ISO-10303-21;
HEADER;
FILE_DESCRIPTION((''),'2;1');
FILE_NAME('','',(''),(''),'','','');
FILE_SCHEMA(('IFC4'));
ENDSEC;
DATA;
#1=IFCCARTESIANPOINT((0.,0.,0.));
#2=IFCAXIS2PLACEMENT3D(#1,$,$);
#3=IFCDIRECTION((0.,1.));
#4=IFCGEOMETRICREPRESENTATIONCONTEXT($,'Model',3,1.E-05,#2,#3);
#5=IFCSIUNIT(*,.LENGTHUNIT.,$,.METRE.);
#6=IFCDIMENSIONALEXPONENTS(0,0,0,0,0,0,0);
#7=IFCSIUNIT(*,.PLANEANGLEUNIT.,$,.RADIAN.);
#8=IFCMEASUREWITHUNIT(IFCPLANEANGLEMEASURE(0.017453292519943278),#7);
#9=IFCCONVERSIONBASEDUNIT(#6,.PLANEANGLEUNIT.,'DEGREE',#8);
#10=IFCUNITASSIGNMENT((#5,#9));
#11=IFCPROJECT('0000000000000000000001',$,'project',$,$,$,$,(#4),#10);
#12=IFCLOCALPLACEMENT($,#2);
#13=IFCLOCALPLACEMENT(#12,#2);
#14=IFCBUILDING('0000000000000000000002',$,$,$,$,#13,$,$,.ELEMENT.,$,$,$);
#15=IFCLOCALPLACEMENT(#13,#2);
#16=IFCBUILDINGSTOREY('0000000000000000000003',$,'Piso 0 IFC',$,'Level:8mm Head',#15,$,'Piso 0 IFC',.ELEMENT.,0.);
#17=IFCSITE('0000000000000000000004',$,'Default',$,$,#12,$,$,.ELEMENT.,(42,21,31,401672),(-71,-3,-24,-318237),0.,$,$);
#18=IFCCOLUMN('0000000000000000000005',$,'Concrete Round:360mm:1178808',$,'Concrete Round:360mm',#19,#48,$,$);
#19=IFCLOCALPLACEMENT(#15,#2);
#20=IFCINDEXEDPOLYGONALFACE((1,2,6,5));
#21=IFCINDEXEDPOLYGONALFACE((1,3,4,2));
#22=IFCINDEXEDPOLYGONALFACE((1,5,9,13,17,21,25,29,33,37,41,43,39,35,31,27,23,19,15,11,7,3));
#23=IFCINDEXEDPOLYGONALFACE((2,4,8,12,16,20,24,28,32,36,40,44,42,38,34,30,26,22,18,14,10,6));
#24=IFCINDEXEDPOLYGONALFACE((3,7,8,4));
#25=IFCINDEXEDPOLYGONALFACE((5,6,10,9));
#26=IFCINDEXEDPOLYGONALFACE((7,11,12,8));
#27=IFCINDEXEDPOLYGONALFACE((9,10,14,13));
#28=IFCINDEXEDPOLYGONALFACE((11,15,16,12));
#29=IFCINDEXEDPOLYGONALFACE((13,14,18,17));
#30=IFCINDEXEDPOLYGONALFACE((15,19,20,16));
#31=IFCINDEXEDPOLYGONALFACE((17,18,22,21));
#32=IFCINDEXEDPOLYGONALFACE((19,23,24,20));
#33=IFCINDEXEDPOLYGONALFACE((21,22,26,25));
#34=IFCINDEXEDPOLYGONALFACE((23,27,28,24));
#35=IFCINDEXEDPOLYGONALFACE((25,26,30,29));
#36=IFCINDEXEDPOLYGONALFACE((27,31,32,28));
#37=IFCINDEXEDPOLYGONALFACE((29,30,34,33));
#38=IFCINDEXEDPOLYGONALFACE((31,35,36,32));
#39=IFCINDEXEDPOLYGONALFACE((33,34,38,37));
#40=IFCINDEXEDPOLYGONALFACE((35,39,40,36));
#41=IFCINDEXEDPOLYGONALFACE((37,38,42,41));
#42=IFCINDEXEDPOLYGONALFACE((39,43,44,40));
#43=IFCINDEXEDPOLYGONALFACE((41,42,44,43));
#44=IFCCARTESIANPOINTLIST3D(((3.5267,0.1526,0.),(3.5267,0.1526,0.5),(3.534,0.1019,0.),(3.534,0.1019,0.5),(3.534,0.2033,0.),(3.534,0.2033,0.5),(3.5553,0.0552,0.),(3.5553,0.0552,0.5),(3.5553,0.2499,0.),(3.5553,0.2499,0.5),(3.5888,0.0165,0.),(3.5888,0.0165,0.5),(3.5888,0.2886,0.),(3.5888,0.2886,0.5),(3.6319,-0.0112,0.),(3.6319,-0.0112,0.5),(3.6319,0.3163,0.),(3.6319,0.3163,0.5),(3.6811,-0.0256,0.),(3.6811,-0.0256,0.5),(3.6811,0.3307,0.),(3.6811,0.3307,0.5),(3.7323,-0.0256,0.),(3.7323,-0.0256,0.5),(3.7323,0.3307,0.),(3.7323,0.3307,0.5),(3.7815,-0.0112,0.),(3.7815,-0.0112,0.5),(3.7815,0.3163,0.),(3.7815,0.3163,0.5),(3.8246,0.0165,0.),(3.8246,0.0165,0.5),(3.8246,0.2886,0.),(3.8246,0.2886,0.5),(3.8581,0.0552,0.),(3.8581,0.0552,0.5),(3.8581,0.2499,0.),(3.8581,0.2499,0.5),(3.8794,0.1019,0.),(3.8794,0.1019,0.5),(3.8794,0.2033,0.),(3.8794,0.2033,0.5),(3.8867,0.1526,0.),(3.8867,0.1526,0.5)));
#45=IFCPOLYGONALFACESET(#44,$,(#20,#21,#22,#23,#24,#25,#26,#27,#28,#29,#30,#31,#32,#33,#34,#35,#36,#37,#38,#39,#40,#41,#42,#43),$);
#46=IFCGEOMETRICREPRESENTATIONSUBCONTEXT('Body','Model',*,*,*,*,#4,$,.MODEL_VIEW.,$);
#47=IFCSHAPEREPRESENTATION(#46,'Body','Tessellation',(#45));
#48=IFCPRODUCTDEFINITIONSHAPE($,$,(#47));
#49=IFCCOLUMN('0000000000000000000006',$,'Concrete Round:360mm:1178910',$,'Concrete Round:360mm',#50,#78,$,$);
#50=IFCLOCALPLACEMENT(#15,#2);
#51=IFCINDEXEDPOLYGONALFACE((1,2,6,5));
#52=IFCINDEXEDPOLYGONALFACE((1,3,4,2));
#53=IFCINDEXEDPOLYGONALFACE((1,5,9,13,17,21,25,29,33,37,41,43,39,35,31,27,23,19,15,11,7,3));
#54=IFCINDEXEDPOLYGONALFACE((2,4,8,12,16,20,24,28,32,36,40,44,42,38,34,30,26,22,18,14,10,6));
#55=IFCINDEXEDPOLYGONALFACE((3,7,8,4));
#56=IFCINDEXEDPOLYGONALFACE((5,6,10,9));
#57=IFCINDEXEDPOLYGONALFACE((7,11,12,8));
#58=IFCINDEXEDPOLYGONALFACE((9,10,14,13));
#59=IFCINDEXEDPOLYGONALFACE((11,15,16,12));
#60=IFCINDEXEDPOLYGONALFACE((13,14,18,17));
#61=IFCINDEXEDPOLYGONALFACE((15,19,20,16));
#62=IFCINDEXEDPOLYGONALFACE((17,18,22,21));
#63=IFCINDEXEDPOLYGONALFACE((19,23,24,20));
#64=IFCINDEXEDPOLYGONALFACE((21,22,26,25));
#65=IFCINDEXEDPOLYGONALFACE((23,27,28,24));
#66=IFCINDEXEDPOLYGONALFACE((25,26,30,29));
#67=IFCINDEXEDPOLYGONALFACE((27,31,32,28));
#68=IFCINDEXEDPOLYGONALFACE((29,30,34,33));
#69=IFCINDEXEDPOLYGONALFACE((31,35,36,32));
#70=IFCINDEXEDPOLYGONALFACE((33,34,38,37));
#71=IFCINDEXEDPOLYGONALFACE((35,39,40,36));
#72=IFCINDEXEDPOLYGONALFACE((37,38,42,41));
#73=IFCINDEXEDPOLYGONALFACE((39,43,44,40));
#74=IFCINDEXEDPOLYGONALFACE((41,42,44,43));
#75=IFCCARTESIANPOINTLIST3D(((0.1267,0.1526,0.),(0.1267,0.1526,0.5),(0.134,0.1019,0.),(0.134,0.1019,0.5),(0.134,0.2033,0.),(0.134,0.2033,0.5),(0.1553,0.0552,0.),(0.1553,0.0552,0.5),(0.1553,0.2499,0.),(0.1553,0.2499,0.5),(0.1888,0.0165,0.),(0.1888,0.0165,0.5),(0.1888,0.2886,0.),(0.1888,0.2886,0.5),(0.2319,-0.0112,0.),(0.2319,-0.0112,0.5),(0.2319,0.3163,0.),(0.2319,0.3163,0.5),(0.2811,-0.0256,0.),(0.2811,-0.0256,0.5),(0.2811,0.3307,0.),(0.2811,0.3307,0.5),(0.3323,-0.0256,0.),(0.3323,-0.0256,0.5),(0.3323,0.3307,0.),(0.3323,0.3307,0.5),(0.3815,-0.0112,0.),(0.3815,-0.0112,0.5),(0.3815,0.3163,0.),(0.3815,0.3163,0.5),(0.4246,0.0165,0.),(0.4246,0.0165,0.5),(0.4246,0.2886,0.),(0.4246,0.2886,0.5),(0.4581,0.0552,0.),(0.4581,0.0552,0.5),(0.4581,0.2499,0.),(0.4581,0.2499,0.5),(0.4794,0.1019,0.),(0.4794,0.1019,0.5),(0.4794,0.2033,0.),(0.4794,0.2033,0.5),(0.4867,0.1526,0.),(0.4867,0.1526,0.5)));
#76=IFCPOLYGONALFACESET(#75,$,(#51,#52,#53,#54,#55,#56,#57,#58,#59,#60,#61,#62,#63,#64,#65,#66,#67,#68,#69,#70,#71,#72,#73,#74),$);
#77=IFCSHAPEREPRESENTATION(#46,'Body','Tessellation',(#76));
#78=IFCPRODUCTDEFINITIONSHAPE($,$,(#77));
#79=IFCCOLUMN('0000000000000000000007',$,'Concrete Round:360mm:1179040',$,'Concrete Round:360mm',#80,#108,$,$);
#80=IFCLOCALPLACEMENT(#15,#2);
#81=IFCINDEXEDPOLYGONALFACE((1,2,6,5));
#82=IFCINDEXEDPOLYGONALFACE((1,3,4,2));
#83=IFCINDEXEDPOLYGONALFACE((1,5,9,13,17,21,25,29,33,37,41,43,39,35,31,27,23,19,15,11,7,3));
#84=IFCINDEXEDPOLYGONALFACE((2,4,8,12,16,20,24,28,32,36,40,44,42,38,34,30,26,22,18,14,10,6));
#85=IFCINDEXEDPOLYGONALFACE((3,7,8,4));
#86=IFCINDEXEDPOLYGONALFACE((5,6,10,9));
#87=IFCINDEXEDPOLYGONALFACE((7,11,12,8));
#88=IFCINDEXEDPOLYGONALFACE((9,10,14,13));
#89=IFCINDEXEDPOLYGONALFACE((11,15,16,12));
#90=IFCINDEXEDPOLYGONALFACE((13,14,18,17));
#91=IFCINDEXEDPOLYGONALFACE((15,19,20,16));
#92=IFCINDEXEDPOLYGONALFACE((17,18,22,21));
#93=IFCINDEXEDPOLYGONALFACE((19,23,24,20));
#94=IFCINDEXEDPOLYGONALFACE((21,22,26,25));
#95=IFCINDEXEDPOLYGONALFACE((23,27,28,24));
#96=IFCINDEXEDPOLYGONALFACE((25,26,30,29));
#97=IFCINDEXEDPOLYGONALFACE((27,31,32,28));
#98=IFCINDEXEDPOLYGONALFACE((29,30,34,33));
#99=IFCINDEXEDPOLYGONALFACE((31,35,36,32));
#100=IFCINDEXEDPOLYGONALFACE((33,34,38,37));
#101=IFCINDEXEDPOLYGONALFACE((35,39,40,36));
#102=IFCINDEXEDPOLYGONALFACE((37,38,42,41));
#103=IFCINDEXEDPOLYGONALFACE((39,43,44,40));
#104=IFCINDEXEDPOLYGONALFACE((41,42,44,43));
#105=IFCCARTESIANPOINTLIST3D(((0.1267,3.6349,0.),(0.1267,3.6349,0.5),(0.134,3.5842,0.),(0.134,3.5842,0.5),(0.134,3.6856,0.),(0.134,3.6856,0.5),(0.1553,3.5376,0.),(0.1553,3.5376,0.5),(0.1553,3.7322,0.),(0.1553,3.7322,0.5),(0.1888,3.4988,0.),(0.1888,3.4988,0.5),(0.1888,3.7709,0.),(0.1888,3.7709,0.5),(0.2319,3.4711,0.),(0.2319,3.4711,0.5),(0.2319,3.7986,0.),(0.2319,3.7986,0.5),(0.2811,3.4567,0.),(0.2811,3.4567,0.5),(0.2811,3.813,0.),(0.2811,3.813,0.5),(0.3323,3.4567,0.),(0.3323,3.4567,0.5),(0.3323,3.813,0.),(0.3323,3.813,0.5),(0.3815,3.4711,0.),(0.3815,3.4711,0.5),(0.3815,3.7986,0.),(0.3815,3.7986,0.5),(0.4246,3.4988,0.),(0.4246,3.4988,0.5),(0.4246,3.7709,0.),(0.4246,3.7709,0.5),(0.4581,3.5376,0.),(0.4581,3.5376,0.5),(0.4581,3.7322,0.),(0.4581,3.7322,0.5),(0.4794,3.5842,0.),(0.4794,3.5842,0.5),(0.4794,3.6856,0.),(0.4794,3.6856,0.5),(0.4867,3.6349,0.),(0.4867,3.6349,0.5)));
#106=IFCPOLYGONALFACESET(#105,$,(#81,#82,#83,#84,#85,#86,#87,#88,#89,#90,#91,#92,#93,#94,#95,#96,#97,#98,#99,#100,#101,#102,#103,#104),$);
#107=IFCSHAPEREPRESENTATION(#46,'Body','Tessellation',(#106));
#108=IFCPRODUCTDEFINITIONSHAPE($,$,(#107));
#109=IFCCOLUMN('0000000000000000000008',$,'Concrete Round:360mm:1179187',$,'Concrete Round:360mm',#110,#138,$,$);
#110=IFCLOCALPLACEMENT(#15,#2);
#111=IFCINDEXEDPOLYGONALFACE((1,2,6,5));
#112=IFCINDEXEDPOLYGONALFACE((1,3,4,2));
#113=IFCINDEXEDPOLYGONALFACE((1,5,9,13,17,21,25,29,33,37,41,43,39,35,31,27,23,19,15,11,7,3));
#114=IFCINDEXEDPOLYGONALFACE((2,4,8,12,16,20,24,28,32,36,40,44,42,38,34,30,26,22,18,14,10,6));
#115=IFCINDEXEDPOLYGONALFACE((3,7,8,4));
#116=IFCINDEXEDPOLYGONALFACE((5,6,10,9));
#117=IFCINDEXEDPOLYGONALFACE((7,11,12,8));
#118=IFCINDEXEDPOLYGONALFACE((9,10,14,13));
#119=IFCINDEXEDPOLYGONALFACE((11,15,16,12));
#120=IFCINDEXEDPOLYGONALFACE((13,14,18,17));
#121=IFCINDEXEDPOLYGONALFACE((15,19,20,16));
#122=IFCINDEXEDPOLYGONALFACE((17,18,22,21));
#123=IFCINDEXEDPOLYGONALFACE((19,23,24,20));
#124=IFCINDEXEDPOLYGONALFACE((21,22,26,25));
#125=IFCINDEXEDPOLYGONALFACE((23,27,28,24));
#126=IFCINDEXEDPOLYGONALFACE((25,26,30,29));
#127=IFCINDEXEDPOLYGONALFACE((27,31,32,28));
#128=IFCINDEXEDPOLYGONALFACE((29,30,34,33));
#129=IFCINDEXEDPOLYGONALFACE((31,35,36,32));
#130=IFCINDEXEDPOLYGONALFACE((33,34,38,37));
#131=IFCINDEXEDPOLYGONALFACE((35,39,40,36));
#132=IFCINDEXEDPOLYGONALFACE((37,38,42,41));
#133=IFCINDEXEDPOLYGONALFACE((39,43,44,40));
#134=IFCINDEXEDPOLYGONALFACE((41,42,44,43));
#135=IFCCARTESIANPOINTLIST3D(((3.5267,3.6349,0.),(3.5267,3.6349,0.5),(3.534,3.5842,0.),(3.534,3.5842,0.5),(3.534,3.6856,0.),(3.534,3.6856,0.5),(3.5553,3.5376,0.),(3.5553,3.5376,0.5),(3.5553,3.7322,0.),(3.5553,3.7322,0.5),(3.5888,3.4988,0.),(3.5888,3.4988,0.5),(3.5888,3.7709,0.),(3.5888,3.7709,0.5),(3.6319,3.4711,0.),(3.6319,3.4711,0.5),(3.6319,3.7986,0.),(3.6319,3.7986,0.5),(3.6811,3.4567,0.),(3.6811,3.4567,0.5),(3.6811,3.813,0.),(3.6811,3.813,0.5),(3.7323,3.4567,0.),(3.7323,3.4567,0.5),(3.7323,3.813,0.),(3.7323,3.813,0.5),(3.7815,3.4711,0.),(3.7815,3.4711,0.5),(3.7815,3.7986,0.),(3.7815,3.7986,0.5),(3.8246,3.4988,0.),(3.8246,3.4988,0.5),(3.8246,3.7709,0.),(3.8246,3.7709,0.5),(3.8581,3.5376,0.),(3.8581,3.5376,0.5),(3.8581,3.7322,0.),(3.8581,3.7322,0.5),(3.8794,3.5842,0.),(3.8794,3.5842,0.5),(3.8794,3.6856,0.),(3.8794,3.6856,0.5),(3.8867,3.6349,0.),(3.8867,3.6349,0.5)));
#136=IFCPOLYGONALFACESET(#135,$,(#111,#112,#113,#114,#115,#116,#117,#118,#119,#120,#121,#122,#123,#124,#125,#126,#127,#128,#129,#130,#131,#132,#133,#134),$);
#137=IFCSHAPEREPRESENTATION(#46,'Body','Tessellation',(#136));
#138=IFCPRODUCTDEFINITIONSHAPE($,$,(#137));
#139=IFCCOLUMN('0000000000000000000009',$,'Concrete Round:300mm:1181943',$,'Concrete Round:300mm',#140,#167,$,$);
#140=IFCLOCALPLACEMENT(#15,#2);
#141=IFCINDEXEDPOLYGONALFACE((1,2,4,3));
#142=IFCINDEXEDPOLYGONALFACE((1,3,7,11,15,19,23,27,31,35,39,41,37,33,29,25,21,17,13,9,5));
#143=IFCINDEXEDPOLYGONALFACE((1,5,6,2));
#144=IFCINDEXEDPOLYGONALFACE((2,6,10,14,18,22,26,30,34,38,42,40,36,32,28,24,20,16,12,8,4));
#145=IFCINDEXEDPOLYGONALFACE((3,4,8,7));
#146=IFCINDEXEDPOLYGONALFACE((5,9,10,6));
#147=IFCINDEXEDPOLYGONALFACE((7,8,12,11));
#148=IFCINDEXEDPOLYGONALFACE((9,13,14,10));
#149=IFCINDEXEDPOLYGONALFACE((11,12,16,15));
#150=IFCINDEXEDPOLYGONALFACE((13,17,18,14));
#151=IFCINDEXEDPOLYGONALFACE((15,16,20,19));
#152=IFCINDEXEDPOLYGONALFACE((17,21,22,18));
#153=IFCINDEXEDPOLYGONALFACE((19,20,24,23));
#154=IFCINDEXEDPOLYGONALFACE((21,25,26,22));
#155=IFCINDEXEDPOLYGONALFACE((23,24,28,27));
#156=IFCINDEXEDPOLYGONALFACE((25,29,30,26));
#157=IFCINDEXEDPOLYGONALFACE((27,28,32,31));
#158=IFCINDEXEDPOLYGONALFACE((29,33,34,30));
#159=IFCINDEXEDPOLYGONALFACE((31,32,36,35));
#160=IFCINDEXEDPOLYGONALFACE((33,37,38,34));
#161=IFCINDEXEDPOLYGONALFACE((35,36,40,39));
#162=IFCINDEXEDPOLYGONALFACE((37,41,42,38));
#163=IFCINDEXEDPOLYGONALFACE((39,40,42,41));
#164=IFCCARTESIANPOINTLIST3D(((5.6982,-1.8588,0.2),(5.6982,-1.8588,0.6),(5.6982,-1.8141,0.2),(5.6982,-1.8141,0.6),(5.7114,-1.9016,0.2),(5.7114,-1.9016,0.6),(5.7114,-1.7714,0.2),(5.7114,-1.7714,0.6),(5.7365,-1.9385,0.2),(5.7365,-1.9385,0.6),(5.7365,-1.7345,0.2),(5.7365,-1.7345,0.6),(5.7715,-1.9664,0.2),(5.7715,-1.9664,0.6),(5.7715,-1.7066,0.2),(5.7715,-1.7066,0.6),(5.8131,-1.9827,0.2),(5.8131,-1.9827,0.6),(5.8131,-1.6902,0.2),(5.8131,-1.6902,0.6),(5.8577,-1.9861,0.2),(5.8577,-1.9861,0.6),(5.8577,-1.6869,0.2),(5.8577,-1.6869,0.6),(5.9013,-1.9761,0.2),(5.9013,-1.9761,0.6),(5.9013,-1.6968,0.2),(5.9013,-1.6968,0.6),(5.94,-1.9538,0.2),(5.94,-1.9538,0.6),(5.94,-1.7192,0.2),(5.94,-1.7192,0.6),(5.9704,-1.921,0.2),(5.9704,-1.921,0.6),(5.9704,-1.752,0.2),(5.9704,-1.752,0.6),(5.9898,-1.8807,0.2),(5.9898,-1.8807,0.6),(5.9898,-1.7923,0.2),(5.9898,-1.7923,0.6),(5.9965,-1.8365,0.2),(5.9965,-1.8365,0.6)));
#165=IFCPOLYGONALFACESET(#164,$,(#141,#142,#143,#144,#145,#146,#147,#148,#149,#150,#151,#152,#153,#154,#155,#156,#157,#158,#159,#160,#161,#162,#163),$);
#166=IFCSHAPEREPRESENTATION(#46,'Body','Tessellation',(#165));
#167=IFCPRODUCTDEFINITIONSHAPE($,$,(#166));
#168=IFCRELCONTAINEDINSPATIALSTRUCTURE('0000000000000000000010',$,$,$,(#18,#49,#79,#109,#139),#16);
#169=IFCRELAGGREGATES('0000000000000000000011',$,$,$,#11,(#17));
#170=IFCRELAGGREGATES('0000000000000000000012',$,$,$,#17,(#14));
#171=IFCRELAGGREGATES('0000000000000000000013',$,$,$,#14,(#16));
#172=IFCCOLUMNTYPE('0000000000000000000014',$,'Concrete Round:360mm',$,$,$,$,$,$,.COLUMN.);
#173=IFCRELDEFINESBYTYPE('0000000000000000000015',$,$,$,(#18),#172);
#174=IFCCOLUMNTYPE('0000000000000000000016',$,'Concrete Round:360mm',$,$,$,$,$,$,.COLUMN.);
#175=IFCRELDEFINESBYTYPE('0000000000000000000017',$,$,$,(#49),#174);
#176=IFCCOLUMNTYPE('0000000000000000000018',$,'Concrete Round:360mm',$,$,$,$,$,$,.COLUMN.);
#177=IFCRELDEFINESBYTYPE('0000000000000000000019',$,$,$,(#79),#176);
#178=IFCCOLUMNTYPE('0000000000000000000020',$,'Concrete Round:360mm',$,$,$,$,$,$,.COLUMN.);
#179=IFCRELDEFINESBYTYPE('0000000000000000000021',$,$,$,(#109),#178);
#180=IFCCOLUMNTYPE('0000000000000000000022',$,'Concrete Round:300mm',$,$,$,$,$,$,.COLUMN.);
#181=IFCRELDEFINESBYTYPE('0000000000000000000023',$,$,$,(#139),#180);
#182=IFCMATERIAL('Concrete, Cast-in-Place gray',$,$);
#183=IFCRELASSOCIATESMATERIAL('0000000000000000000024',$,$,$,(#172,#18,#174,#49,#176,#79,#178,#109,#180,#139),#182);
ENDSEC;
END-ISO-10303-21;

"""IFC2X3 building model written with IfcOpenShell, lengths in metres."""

from ifc_helpers import new_model, entity, si_unit, converted_unit, direction, frame, frame_2d, origin, origin_2d_with_axis, place, context, subcontext, project, spatial, circle, extrude, source, transform, mapped, material, type_object, type_shapes, element, save


model = new_model("IFC2X3")

# Units and contexts
model_context = context("Model", 3, precision=1e-05, world=origin(), true_north=direction((0.0, 1.0)))
body_context = subcontext(model_context, "Body", "Model", "MODEL_VIEW")
ifc_project = project(units=[si_unit("LENGTHUNIT", "METRE"), converted_unit("PLANEANGLEUNIT", "DEGREE", entity("IfcPlaneAngleMeasure", 0.017453292519943278), si_unit("PLANEANGLEUNIT", "RADIAN"), dimensions=[0, 0, 0, 0, 0, 0, 0])], contexts=[model_context])

# Site, building, storey
site_placement = place(None, origin())
site = spatial("IfcSite", under=ifc_project, at=site_placement, Name="Default", CompositionType="ELEMENT", RefLatitude=(42, 21, 31, 401672), RefLongitude=(-71, -3, -24, -318237), RefElevation=0.0)
building_placement = place(site_placement, origin())
building = spatial("IfcBuilding", under=site, at=building_placement, CompositionType="ELEMENT")
storey_placement = place(building_placement, origin())
storey = spatial("IfcBuildingStorey", under=building, at=storey_placement, Name="Piso 0 IFC", ObjectType="Level:8mm Head", LongName="Piso 0 IFC", CompositionType="ELEMENT", Elevation=0.0)

# Columns
ifc_material_1 = material(Name="Concrete, Cast-in-Place gray")
column_type_1 = type_object("IfcColumnType", Name="Concrete Round:360mm", PredefinedType="COLUMN", material=ifc_material_1)
shared_shape_1 = source(origin(), body_context, "Body", "SweptSolid", [
    extrude(circle(Radius=0.18, at=frame_2d((0.0, 0.0), x_axis=(1.0, 0.0))), frame((3.7067, 0.1526, 0.0)), (0.0, 0.0, 1.0), 0.5),
])
type_shapes(column_type_1, [shared_shape_1])
column_1_placement = place(storey_placement, origin())
element("IfcColumn", 1, at=column_1_placement, inside=storey, type_object=column_type_1, material=ifc_material_1, Name="Concrete Round:360mm:1178808", ObjectType="Concrete Round:360mm", context=body_context, shape_type="MappedRepresentation", body=[
    mapped(shared_shape_1, transform((0.0, 0.0, 0.0), scale=1.0)),
])
column_type_2 = type_object("IfcColumnType", Name="Concrete Round:360mm", PredefinedType="COLUMN", material=ifc_material_1)
shared_shape_2 = source(origin(), body_context, "Body", "SweptSolid", [
    extrude(circle(Radius=0.18, at=frame_2d((0.0, 0.0), x_axis=(1.0, 0.0))), frame((0.3067, 0.1526, 0.0)), (0.0, 0.0, 1.0), 0.5),
])
type_shapes(column_type_2, [shared_shape_2])
column_2_placement = place(storey_placement, origin())
element("IfcColumn", 2, at=column_2_placement, inside=storey, type_object=column_type_2, material=ifc_material_1, Name="Concrete Round:360mm:1178910", ObjectType="Concrete Round:360mm", context=body_context, shape_type="MappedRepresentation", body=[
    mapped(shared_shape_2, transform((0.0, 0.0, 0.0), scale=1.0)),
])
column_type_3 = type_object("IfcColumnType", Name="Concrete Round:360mm", PredefinedType="COLUMN", material=ifc_material_1)
shared_shape_3 = source(origin(), body_context, "Body", "SweptSolid", [
    extrude(circle(Radius=0.18, at=origin_2d_with_axis()), frame((0.3067, 3.6349, 0.0)), (0.0, 0.0, 1.0), 0.5),
])
type_shapes(column_type_3, [shared_shape_3])
column_3_placement = place(storey_placement, origin())
element("IfcColumn", 3, at=column_3_placement, inside=storey, type_object=column_type_3, material=ifc_material_1, Name="Concrete Round:360mm:1179040", ObjectType="Concrete Round:360mm", context=body_context, shape_type="MappedRepresentation", body=[
    mapped(shared_shape_3, transform((0.0, 0.0, 0.0), scale=1.0)),
])
column_type_4 = type_object("IfcColumnType", Name="Concrete Round:360mm", PredefinedType="COLUMN", material=ifc_material_1)
shared_shape_4 = source(origin(), body_context, "Body", "SweptSolid", [
    extrude(circle(Radius=0.18, at=origin_2d_with_axis()), frame((3.7067, 3.6349, 0.0)), (0.0, 0.0, 1.0), 0.5),
])
type_shapes(column_type_4, [shared_shape_4])
column_4_placement = place(storey_placement, origin())
element("IfcColumn", 4, at=column_4_placement, inside=storey, type_object=column_type_4, material=ifc_material_1, Name="Concrete Round:360mm:1179187", ObjectType="Concrete Round:360mm", context=body_context, shape_type="MappedRepresentation", body=[
    mapped(shared_shape_4, transform((0.0, 0.0, 0.0), scale=1.0)),
])
column_type_5 = type_object("IfcColumnType", Name="Concrete Round:300mm", PredefinedType="COLUMN", material=ifc_material_1)
shared_shape_5 = source(origin(), body_context, "Body", "SweptSolid", [
    extrude(circle(Radius=0.15, at=frame_2d((0.0, 0.0), x_axis=(1.0, 0.0))), frame((5.8465, -1.8365, 0.2)), (0.0, 0.0, 1.0), 0.4),
])
type_shapes(column_type_5, [shared_shape_5])
column_5_placement = place(storey_placement, origin())
element("IfcColumn", 5, at=column_5_placement, inside=storey, type_object=column_type_5, material=ifc_material_1, Name="Concrete Round:300mm:1181943", ObjectType="Concrete Round:300mm", context=body_context, shape_type="MappedRepresentation", body=[
    mapped(shared_shape_5, transform((0.0, 0.0, 0.0), scale=1.0)),
])

save(model, "model.ifc")
